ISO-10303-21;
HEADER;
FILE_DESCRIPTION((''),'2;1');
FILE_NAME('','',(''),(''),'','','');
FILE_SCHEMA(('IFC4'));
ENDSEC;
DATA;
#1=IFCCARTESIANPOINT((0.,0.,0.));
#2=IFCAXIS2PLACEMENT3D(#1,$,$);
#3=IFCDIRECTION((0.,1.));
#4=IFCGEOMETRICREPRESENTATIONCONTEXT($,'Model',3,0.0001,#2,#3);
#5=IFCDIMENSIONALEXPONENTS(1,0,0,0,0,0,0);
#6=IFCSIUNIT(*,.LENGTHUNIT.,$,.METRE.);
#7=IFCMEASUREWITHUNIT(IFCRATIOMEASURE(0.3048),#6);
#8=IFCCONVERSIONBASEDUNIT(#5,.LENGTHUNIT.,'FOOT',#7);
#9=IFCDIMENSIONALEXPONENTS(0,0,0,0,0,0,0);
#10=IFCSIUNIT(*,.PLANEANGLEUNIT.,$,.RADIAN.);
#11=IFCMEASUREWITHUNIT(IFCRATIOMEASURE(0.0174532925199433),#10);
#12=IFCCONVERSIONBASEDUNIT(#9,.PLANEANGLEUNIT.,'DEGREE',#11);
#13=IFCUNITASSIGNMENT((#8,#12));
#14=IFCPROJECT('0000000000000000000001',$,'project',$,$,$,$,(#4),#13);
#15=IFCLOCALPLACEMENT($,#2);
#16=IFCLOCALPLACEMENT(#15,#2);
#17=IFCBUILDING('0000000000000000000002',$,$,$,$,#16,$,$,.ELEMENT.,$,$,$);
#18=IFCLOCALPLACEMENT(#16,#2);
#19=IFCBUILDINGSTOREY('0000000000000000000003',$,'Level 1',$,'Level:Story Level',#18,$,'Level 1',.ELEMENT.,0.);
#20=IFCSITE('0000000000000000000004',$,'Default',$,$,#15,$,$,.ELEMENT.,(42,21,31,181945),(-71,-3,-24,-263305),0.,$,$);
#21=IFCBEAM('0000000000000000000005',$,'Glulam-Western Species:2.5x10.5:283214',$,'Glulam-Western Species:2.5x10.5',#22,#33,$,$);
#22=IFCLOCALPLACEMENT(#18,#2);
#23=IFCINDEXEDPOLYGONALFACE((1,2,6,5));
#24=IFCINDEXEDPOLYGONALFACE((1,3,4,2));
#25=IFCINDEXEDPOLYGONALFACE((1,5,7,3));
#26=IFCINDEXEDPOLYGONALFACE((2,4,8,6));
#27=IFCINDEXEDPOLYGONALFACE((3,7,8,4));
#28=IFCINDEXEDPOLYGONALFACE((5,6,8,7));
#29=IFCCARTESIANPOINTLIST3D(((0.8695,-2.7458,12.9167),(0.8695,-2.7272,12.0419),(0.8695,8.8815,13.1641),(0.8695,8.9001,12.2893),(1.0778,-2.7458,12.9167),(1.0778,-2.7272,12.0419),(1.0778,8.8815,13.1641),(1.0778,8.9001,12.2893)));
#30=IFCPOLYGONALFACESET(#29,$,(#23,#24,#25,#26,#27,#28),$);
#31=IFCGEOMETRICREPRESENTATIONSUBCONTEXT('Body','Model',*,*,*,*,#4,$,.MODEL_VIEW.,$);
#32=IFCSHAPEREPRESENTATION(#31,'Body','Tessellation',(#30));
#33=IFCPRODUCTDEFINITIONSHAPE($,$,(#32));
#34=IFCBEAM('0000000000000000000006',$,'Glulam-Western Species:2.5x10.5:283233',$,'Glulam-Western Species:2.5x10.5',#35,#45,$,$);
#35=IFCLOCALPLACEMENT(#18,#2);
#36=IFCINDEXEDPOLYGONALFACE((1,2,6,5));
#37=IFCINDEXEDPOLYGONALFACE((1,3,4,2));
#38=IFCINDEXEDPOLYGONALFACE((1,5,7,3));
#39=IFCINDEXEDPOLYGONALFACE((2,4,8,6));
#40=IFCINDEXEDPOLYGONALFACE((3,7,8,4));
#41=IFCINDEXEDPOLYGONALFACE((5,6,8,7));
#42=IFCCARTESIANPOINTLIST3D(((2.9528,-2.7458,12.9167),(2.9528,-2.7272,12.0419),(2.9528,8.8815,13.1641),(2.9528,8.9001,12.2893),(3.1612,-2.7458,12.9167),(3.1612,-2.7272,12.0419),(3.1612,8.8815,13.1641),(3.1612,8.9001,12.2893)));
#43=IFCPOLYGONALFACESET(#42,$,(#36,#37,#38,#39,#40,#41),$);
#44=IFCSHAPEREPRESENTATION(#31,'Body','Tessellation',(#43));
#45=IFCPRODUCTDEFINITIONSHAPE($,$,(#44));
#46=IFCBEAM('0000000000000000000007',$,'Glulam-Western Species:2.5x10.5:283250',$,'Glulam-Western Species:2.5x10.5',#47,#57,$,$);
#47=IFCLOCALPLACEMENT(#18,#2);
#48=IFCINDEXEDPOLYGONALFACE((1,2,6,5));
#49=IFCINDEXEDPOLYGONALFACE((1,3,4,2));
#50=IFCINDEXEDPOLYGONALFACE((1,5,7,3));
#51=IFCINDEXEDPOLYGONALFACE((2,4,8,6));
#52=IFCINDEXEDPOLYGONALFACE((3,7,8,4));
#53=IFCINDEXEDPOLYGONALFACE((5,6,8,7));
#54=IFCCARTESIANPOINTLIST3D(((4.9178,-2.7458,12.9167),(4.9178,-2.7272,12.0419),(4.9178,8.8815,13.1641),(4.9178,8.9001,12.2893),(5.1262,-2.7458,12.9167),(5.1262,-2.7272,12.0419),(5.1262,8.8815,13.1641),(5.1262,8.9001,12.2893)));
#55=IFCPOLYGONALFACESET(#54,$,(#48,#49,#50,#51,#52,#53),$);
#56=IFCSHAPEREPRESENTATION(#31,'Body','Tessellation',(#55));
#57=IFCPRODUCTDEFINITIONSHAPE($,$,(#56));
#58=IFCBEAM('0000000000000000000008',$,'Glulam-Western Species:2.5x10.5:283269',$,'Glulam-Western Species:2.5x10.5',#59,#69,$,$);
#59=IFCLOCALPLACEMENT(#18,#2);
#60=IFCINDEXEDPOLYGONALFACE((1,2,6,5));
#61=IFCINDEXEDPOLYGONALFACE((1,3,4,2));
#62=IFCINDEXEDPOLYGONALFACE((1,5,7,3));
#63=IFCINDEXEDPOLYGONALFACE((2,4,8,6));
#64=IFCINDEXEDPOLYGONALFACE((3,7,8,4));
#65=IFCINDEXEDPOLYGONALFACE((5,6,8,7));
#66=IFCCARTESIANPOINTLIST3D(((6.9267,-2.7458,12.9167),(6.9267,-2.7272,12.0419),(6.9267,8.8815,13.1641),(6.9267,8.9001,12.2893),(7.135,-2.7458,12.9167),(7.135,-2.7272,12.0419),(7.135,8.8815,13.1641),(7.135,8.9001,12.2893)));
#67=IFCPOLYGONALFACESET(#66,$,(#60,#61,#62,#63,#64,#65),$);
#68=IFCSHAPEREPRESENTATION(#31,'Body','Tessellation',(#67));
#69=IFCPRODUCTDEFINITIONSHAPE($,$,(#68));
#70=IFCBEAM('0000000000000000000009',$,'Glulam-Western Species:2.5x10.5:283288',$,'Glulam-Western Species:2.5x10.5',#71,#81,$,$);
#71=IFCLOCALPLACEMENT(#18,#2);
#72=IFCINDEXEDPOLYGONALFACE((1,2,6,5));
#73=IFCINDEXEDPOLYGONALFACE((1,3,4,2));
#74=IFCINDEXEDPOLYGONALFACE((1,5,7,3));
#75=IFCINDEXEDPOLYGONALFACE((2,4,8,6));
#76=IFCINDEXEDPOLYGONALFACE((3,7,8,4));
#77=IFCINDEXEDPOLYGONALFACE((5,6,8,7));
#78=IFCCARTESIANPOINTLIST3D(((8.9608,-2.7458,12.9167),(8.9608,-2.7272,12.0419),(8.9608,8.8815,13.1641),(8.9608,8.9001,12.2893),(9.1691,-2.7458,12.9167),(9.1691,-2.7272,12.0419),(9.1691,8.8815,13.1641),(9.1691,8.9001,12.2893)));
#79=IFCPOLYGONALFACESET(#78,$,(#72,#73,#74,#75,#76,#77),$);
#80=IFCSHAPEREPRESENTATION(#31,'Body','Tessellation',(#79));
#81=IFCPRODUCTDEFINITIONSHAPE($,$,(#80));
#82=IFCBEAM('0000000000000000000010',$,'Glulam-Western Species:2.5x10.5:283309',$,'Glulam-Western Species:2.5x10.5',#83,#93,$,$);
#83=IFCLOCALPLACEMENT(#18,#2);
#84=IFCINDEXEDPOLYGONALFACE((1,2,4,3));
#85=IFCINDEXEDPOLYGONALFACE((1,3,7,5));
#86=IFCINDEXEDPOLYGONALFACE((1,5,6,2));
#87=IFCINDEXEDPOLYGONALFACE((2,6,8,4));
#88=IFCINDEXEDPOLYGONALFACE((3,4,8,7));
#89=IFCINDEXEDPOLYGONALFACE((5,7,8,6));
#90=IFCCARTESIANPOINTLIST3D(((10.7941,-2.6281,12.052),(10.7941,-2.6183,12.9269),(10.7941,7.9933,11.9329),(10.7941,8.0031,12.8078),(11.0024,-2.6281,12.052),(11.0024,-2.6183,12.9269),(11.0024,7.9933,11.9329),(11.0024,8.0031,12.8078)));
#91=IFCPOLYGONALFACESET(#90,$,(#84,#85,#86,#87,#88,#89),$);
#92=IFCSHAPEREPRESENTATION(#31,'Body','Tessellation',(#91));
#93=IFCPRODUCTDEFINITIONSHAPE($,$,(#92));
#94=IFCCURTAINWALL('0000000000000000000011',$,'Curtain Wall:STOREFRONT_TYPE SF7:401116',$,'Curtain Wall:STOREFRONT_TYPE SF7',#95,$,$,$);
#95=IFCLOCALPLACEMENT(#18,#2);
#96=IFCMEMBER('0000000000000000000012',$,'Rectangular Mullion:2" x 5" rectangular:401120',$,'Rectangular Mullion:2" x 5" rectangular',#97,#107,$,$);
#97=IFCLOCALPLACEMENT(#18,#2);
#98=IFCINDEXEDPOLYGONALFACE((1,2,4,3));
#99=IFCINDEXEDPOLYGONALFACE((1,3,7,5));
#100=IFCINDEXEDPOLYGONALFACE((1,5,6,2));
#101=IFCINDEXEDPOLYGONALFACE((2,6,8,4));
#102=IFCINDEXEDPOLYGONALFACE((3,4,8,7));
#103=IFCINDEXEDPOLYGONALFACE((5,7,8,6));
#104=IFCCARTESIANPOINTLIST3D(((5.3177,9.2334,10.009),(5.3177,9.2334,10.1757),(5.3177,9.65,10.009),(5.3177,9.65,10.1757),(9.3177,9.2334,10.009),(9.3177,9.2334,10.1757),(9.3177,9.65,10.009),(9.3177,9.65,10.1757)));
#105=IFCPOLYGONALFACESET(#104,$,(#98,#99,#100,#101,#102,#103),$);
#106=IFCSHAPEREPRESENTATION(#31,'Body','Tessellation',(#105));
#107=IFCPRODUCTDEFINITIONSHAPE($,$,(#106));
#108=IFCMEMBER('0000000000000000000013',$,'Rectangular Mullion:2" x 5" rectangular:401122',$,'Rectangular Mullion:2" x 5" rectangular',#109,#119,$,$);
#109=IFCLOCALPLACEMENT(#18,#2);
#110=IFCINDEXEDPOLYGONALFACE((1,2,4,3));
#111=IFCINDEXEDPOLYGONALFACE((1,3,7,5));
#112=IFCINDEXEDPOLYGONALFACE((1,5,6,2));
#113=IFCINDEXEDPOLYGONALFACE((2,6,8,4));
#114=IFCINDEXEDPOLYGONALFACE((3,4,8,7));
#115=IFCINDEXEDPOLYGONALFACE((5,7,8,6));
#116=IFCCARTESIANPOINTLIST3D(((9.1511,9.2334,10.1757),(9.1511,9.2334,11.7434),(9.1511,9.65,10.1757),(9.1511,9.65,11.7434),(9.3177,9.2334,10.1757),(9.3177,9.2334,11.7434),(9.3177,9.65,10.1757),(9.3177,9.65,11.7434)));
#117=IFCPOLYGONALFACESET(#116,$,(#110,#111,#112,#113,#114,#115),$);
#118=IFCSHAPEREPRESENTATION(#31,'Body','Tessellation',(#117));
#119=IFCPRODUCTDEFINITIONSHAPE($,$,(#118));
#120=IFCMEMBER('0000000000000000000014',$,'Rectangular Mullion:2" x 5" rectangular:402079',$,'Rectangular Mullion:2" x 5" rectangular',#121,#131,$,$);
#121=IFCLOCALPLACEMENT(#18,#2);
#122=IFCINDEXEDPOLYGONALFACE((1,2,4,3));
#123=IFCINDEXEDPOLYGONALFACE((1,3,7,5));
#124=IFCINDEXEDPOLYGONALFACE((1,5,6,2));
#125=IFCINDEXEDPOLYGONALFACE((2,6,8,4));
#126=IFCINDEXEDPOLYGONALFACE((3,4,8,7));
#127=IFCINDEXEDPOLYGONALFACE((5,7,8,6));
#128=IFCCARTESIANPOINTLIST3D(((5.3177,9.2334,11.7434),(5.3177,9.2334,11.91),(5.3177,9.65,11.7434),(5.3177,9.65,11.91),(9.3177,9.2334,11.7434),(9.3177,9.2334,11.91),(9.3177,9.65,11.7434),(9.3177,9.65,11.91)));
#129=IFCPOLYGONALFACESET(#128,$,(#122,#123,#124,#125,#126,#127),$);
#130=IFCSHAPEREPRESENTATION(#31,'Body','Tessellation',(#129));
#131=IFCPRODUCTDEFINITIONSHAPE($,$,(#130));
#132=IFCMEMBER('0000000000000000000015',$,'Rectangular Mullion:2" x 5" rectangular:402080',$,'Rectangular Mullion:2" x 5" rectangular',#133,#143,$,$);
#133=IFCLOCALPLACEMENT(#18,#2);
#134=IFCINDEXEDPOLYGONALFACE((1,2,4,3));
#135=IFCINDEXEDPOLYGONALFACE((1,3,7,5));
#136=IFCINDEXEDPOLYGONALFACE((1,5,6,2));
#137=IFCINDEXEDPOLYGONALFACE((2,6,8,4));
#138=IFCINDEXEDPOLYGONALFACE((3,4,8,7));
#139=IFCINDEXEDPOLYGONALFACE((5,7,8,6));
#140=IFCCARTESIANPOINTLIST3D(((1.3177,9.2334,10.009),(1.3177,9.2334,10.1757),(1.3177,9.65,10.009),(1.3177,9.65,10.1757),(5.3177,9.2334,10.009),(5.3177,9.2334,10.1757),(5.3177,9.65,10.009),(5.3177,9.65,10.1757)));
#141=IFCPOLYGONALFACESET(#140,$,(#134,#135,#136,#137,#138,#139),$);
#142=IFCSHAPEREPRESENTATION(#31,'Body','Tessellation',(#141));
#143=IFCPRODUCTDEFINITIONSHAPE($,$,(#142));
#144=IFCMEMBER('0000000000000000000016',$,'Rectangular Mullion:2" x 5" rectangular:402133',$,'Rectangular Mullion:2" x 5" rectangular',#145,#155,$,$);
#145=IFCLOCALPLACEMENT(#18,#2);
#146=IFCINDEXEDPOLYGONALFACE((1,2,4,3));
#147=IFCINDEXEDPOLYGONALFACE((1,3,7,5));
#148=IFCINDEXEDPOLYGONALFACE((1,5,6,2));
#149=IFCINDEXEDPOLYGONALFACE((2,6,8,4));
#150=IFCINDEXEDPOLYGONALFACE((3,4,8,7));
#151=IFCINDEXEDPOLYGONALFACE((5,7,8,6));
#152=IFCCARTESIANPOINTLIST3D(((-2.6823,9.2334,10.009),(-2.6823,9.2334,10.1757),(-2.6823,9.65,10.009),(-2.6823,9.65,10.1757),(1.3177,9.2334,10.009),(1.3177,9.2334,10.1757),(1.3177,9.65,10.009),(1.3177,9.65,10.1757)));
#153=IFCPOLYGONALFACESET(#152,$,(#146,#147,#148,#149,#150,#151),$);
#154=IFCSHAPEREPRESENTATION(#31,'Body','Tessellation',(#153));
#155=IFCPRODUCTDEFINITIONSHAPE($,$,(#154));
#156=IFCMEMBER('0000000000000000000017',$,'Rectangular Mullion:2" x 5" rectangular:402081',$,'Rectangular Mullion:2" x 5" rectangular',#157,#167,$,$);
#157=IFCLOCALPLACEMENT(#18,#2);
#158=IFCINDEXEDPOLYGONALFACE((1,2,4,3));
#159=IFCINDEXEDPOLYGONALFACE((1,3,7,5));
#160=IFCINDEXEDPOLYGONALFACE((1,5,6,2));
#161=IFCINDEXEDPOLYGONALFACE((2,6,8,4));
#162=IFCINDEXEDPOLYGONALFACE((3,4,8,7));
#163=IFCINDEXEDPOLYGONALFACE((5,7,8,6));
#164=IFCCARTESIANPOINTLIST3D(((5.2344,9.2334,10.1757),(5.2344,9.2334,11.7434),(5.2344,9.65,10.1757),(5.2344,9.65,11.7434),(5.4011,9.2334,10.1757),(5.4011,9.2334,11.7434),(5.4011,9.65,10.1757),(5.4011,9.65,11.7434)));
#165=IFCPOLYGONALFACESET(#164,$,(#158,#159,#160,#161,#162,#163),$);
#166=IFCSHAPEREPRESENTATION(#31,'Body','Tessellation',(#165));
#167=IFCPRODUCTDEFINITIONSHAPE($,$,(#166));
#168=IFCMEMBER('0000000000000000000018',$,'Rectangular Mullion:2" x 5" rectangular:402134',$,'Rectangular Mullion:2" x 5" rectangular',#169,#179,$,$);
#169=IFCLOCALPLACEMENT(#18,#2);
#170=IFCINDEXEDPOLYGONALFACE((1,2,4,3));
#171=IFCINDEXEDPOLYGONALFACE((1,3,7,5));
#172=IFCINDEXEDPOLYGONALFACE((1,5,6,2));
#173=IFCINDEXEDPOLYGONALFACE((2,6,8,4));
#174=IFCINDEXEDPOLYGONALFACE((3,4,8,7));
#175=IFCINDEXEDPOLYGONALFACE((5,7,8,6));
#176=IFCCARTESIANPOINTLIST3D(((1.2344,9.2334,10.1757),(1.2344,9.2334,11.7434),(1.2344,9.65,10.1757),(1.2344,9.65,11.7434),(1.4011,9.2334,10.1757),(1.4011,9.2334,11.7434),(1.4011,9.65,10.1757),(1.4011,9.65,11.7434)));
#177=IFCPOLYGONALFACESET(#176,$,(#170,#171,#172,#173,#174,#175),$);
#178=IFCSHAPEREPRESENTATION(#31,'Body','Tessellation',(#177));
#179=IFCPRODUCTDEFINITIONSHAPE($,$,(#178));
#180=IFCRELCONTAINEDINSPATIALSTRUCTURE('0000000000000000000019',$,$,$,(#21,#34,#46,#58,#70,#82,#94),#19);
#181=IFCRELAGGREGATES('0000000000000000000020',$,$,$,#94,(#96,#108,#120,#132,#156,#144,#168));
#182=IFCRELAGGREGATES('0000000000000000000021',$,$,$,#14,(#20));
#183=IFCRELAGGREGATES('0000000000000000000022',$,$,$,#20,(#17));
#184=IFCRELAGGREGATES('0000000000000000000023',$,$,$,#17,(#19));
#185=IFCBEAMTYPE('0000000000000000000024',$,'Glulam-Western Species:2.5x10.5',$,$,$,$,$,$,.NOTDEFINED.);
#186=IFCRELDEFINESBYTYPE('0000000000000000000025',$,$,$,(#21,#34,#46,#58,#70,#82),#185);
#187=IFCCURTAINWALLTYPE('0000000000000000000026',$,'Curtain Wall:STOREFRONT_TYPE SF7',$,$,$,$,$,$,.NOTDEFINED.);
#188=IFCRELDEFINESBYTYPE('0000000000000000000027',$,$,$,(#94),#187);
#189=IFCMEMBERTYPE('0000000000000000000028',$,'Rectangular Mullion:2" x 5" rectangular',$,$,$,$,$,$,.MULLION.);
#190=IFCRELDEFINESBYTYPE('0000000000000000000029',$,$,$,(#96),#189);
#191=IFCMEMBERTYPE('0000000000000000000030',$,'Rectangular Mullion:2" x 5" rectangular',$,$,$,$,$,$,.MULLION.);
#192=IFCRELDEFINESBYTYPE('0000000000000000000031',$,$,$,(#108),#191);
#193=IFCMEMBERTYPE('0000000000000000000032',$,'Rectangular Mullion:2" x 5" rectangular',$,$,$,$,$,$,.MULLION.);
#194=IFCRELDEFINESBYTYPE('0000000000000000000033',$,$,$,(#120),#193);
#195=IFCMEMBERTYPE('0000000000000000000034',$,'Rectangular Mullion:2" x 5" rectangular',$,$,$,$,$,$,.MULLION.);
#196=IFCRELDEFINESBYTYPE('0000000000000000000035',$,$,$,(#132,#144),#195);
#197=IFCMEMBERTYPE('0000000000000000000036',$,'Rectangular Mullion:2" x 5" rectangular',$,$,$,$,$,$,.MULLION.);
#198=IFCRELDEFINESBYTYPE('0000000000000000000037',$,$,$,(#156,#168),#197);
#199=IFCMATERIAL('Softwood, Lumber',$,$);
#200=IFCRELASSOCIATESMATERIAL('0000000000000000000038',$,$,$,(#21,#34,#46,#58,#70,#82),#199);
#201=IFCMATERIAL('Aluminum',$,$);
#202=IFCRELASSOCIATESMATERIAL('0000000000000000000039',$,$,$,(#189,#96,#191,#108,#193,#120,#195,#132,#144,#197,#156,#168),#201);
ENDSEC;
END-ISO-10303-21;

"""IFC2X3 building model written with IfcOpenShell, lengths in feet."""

from ifc_helpers import new_model, entity, si_unit, converted_unit, direction, frame, frame_2d, origin, origin_2d_with_axis, place, context, subcontext, project, spatial, rectangle, extrude, source, transform, mapped, material, type_object, type_shapes, element, aggregate, save


model = new_model("IFC2X3")

# Units and contexts
model_context = context("Model", 3, precision=0.0001, world=origin(), true_north=direction((0.0, 1.0)))
body_context = subcontext(model_context, "Body", "Model", "MODEL_VIEW")
ifc_project = project(units=[converted_unit("LENGTHUNIT", "FOOT", entity("IfcRatioMeasure", 0.3048), si_unit("LENGTHUNIT", "METRE"), dimensions=[1, 0, 0, 0, 0, 0, 0]), converted_unit("PLANEANGLEUNIT", "DEGREE", entity("IfcRatioMeasure", 0.0174532925199433), si_unit("PLANEANGLEUNIT", "RADIAN"), dimensions=[0, 0, 0, 0, 0, 0, 0])], contexts=[model_context])

# Site, building, storey
site_placement = place(None, origin())
site = spatial("IfcSite", under=ifc_project, at=site_placement, Name="Default", CompositionType="ELEMENT", RefLatitude=(42, 21, 31, 181945), RefLongitude=(-71, -3, -24, -263305), RefElevation=0.0)
building_placement = place(site_placement, origin())
building = spatial("IfcBuilding", under=site, at=building_placement, CompositionType="ELEMENT")
storey_placement = place(building_placement, origin())
storey = spatial("IfcBuildingStorey", under=building, at=storey_placement, Name="Level 1", ObjectType="Level:Story Level", LongName="Level 1", CompositionType="ELEMENT", Elevation=0.0)

# Beams
ifc_material_1 = material(Name="Softwood, Lumber")
beam_type = type_object("IfcBeamType", Name="Glulam-Western Species:2.5x10.5", PredefinedType="NOTDEFINED")
beam_1_placement = place(storey_placement, frame((0.9737, 9.0042, 13.1667), z_axis=(0.0, -0.021272, 0.999774), x_axis=(0.0, -0.999774, -0.021272)))
element("IfcBeam", 1, at=beam_1_placement, inside=storey, type_object=beam_type, material=ifc_material_1, Name="Glulam-Western Species:2.5x10.5:283214", ObjectType="Glulam-Western Species:2.5x10.5", context=body_context, shape_type="SweptSolid", body=[
    extrude(rectangle(XDim=0.875, YDim=0.2083, at=frame_2d((0.0, 0.0), x_axis=(1.0, 0.0))), frame((0.1228, 0.0, -0.4375), z_axis=(1.0, 0.0, 0.0), x_axis=(0.0, 0.0, -1.0)), (0.0, 0.0, 1.0), 11.6299),
])
beam_2_placement = place(storey_placement, frame((3.057, 9.0042, 13.1667), z_axis=(0.0, -0.021272, 0.999774), x_axis=(0.0, -0.999774, -0.021272)))
element("IfcBeam", 2, at=beam_2_placement, inside=storey, type_object=beam_type, material=ifc_material_1, Name="Glulam-Western Species:2.5x10.5:283233", ObjectType="Glulam-Western Species:2.5x10.5", context=body_context, shape_type="SweptSolid", body=[
    extrude(rectangle(XDim=0.875, YDim=0.2083, at=frame_2d((0.0, 0.0), x_axis=(1.0, 0.0))), frame((0.1228, 0.0, -0.4375), z_axis=(1.0, 0.0, 0.0), x_axis=(0.0, 0.0, -1.0)), (0.0, 0.0, 1.0), 11.6299),
])
beam_3_placement = place(storey_placement, frame((5.022, 9.0042, 13.1667), z_axis=(0.0, -0.021272, 0.999774), x_axis=(0.0, -0.999774, -0.021272)))
element("IfcBeam", 3, at=beam_3_placement, inside=storey, type_object=beam_type, material=ifc_material_1, Name="Glulam-Western Species:2.5x10.5:283250", ObjectType="Glulam-Western Species:2.5x10.5", context=body_context, shape_type="SweptSolid", body=[
    extrude(rectangle(XDim=0.875, YDim=0.2083, at=origin_2d_with_axis()), frame((0.1228, 0.0, -0.4375), z_axis=(1.0, 0.0, 0.0), x_axis=(0.0, 0.0, -1.0)), (0.0, 0.0, 1.0), 11.6299),
])
for number, where, z_axis, x_axis, name in (
    (4, (7.0309, 9.0042, 13.1667), (0.0, -0.021272, 0.999774), (0.0, -0.999774, -0.021272), "Glulam-Western Species:2.5x10.5:283269"),
    (5, (9.0649, 9.0042, 13.1667), (0.0, -0.021272, 0.999774), (0.0, -0.999774, -0.021272), "Glulam-Western Species:2.5x10.5:283288"),
):
    element("IfcBeam", number, at=place(storey_placement, frame(where, z_axis=z_axis, x_axis=x_axis)), inside=storey, type_object=beam_type, material=ifc_material_1, Name=name, ObjectType="Glulam-Western Species:2.5x10.5", context=body_context, shape_type="SweptSolid", body=[
        extrude(rectangle(XDim=0.875, YDim=0.2083, at=origin_2d_with_axis()), frame((0.1228, 0.0, -0.4375), z_axis=(1.0, 0.0, 0.0), x_axis=(0.0, 0.0, -1.0)), (0.0, 0.0, 1.0), 11.6299),
    ])
beam_4_placement = place(storey_placement, frame((10.8983, 9.4452, 12.7917), z_axis=(0.0, 0.011209, 0.999937), x_axis=(0.0, -0.999937, 0.011209)))
element("IfcBeam", 6, at=beam_4_placement, inside=storey, type_object=beam_type, material=ifc_material_1, Name="Glulam-Western Species:2.5x10.5:283309", ObjectType="Glulam-Western Species:2.5x10.5", context=body_context, shape_type="SweptSolid", body=[
    extrude(rectangle(XDim=0.875, YDim=0.2083, at=frame_2d((0.0, 0.0), x_axis=(1.0, 0.0))), frame((1.4422, 0.0, -0.4375), z_axis=(1.0, 0.0, 0.0), x_axis=(0.0, 0.0, -1.0)), (0.0, 0.0, 1.0), 10.622),
])

# Curtain wall, members
curtain_wall_type = type_object("IfcCurtainWallType", Name="Curtain Wall:STOREFRONT_TYPE SF7", PredefinedType="NOTDEFINED")
curtain_wall_placement = place(storey_placement, origin())
curtain_wall = element("IfcCurtainWall", 7, at=curtain_wall_placement, inside=storey, type_object=curtain_wall_type, Name="Curtain Wall:STOREFRONT_TYPE SF7:401116", ObjectType="Curtain Wall:STOREFRONT_TYPE SF7")
ifc_material_2 = material(Name="Aluminum")
member_type_1 = type_object("IfcMemberType", Name="Rectangular Mullion:2\" x 5\" rectangular", PredefinedType="MULLION", material=ifc_material_2)
shared_shape_1 = source(origin(), body_context, "Body", "SweptSolid", [
    extrude(rectangle(XDim=0.4167, YDim=0.1667, at=origin_2d_with_axis()), frame((-0.0833, 0.0, -4.0), z_axis=(0.0, 0.0, 1.0), x_axis=(0.0, -1.0, 0.0)), (0.0, 0.0, 1.0), 4.0),
])
type_shapes(member_type_1, [shared_shape_1])
member_1_placement = place(curtain_wall_placement, frame((9.3177, 9.4417, 10.009), z_axis=(1.0, 0.0, 0.0), x_axis=(0.0, 0.0, -1.0)))
member_1 = element("IfcMember", 8, at=member_1_placement, type_object=member_type_1, material=ifc_material_2, Name="Rectangular Mullion:2\" x 5\" rectangular:401120", ObjectType="Rectangular Mullion:2\" x 5\" rectangular", context=body_context, shape_type="MappedRepresentation", body=[
    mapped(shared_shape_1, transform((0.0, 0.0, 0.0), scale=1.0)),
])
member_type_2 = type_object("IfcMemberType", Name="Rectangular Mullion:2\" x 5\" rectangular", PredefinedType="MULLION", material=ifc_material_2)
shared_shape_2 = source(origin(), body_context, "Body", "SweptSolid", [
    extrude(rectangle(XDim=0.4167, YDim=0.1667, at=origin_2d_with_axis()), frame((-0.0833, 0.0, -1.5677), z_axis=(0.0, 0.0, 1.0), x_axis=(0.0, -1.0, 0.0)), (0.0, 0.0, 1.0), 1.5677),
])
type_shapes(member_type_2, [shared_shape_2])
member_2_placement = place(curtain_wall_placement, frame((9.3177, 9.4417, 11.7434)))
member_2 = element("IfcMember", 9, at=member_2_placement, type_object=member_type_2, material=ifc_material_2, Name="Rectangular Mullion:2\" x 5\" rectangular:401122", ObjectType="Rectangular Mullion:2\" x 5\" rectangular", context=body_context, shape_type="MappedRepresentation", body=[
    mapped(shared_shape_2, transform((0.0, 0.0, 0.0), scale=1.0)),
])
member_type_3 = type_object("IfcMemberType", Name="Rectangular Mullion:2\" x 5\" rectangular", PredefinedType="MULLION", material=ifc_material_2)
shared_shape_3 = source(origin(), body_context, "Body", "SweptSolid", [
    extrude(rectangle(XDim=0.4167, YDim=0.1667, at=origin_2d_with_axis()), frame((-0.0833, 0.0, -4.0), z_axis=(0.0, 0.0, 1.0), x_axis=(0.0, -1.0, 0.0)), (0.0, 0.0, 1.0), 4.0),
])
type_shapes(member_type_3, [shared_shape_3])
member_3_placement = place(curtain_wall_placement, frame((5.3177, 9.4417, 11.91), z_axis=(-1.0, 0.0, 0.0), x_axis=(0.0, 0.0, 1.0)))
member_3 = element("IfcMember", 10, at=member_3_placement, type_object=member_type_3, material=ifc_material_2, Name="Rectangular Mullion:2\" x 5\" rectangular:402079", ObjectType="Rectangular Mullion:2\" x 5\" rectangular", context=body_context, shape_type="MappedRepresentation", body=[
    mapped(shared_shape_3, transform((0.0, 0.0, 0.0), scale=1.0)),
])
member_type_4 = type_object("IfcMemberType", Name="Rectangular Mullion:2\" x 5\" rectangular", PredefinedType="MULLION", material=ifc_material_2)
shared_shape_4 = source(origin(), body_context, "Body", "SweptSolid", [
    extrude(rectangle(XDim=0.4167, YDim=0.1667, at=origin_2d_with_axis()), frame((-0.0833, 0.0, -4.0), z_axis=(0.0, 0.0, 1.0), x_axis=(0.0, -1.0, 0.0)), (0.0, 0.0, 1.0), 4.0),
])
type_shapes(member_type_4, [shared_shape_4])
member_4_placement = place(curtain_wall_placement, frame((5.3177, 9.4417, 10.009), z_axis=(1.0, 0.0, 0.0), x_axis=(0.0, 0.0, -1.0)))
member_4 = element("IfcMember", 11, at=member_4_placement, type_object=member_type_4, material=ifc_material_2, Name="Rectangular Mullion:2\" x 5\" rectangular:402080", ObjectType="Rectangular Mullion:2\" x 5\" rectangular", context=body_context, shape_type="MappedRepresentation", body=[
    mapped(shared_shape_4, transform((0.0, 0.0, 0.0), scale=1.0)),
])
member_5_placement = place(curtain_wall_placement, frame((1.3177, 9.4417, 10.009), z_axis=(1.0, 0.0, 0.0), x_axis=(0.0, 0.0, -1.0)))
member_5 = element("IfcMember", 12, at=member_5_placement, type_object=member_type_4, material=ifc_material_2, Name="Rectangular Mullion:2\" x 5\" rectangular:402133", ObjectType="Rectangular Mullion:2\" x 5\" rectangular", context=body_context, shape_type="MappedRepresentation", body=[
    mapped(shared_shape_4, transform((0.0, 0.0, 0.0), scale=1.0)),
])
member_type_5 = type_object("IfcMemberType", Name="Rectangular Mullion:2\" x 5\" rectangular", PredefinedType="MULLION", material=ifc_material_2)
shared_shape_5 = source(origin(), body_context, "Body", "SweptSolid", [
    extrude(rectangle(XDim=0.4167, YDim=0.1667, at=origin_2d_with_axis()), frame((0.0, 0.0, -1.5677), z_axis=(0.0, 0.0, 1.0), x_axis=(0.0, -1.0, 0.0)), (0.0, 0.0, 1.0), 1.5677),
])
type_shapes(member_type_5, [shared_shape_5])
member_6_placement = place(curtain_wall_placement, frame((5.3177, 9.4417, 10.1757), z_axis=(0.0, 0.0, -1.0), x_axis=(-1.0, 0.0, 0.0)))
member_6 = element("IfcMember", 13, at=member_6_placement, type_object=member_type_5, material=ifc_material_2, Name="Rectangular Mullion:2\" x 5\" rectangular:402081", ObjectType="Rectangular Mullion:2\" x 5\" rectangular", context=body_context, shape_type="MappedRepresentation", body=[
    mapped(shared_shape_5, transform((0.0, 0.0, 0.0), scale=1.0)),
])
member_7_placement = place(curtain_wall_placement, frame((1.3177, 9.4417, 10.1757), z_axis=(0.0, 0.0, -1.0), x_axis=(-1.0, 0.0, 0.0)))
member_7 = element("IfcMember", 14, at=member_7_placement, type_object=member_type_5, material=ifc_material_2, Name="Rectangular Mullion:2\" x 5\" rectangular:402134", ObjectType="Rectangular Mullion:2\" x 5\" rectangular", context=body_context, shape_type="MappedRepresentation", body=[
    mapped(shared_shape_5, transform((0.0, 0.0, 0.0), scale=1.0)),
])
aggregate(curtain_wall, [member_1, member_2, member_3, member_4, member_6, member_5, member_7])

save(model, "model.ifc")
